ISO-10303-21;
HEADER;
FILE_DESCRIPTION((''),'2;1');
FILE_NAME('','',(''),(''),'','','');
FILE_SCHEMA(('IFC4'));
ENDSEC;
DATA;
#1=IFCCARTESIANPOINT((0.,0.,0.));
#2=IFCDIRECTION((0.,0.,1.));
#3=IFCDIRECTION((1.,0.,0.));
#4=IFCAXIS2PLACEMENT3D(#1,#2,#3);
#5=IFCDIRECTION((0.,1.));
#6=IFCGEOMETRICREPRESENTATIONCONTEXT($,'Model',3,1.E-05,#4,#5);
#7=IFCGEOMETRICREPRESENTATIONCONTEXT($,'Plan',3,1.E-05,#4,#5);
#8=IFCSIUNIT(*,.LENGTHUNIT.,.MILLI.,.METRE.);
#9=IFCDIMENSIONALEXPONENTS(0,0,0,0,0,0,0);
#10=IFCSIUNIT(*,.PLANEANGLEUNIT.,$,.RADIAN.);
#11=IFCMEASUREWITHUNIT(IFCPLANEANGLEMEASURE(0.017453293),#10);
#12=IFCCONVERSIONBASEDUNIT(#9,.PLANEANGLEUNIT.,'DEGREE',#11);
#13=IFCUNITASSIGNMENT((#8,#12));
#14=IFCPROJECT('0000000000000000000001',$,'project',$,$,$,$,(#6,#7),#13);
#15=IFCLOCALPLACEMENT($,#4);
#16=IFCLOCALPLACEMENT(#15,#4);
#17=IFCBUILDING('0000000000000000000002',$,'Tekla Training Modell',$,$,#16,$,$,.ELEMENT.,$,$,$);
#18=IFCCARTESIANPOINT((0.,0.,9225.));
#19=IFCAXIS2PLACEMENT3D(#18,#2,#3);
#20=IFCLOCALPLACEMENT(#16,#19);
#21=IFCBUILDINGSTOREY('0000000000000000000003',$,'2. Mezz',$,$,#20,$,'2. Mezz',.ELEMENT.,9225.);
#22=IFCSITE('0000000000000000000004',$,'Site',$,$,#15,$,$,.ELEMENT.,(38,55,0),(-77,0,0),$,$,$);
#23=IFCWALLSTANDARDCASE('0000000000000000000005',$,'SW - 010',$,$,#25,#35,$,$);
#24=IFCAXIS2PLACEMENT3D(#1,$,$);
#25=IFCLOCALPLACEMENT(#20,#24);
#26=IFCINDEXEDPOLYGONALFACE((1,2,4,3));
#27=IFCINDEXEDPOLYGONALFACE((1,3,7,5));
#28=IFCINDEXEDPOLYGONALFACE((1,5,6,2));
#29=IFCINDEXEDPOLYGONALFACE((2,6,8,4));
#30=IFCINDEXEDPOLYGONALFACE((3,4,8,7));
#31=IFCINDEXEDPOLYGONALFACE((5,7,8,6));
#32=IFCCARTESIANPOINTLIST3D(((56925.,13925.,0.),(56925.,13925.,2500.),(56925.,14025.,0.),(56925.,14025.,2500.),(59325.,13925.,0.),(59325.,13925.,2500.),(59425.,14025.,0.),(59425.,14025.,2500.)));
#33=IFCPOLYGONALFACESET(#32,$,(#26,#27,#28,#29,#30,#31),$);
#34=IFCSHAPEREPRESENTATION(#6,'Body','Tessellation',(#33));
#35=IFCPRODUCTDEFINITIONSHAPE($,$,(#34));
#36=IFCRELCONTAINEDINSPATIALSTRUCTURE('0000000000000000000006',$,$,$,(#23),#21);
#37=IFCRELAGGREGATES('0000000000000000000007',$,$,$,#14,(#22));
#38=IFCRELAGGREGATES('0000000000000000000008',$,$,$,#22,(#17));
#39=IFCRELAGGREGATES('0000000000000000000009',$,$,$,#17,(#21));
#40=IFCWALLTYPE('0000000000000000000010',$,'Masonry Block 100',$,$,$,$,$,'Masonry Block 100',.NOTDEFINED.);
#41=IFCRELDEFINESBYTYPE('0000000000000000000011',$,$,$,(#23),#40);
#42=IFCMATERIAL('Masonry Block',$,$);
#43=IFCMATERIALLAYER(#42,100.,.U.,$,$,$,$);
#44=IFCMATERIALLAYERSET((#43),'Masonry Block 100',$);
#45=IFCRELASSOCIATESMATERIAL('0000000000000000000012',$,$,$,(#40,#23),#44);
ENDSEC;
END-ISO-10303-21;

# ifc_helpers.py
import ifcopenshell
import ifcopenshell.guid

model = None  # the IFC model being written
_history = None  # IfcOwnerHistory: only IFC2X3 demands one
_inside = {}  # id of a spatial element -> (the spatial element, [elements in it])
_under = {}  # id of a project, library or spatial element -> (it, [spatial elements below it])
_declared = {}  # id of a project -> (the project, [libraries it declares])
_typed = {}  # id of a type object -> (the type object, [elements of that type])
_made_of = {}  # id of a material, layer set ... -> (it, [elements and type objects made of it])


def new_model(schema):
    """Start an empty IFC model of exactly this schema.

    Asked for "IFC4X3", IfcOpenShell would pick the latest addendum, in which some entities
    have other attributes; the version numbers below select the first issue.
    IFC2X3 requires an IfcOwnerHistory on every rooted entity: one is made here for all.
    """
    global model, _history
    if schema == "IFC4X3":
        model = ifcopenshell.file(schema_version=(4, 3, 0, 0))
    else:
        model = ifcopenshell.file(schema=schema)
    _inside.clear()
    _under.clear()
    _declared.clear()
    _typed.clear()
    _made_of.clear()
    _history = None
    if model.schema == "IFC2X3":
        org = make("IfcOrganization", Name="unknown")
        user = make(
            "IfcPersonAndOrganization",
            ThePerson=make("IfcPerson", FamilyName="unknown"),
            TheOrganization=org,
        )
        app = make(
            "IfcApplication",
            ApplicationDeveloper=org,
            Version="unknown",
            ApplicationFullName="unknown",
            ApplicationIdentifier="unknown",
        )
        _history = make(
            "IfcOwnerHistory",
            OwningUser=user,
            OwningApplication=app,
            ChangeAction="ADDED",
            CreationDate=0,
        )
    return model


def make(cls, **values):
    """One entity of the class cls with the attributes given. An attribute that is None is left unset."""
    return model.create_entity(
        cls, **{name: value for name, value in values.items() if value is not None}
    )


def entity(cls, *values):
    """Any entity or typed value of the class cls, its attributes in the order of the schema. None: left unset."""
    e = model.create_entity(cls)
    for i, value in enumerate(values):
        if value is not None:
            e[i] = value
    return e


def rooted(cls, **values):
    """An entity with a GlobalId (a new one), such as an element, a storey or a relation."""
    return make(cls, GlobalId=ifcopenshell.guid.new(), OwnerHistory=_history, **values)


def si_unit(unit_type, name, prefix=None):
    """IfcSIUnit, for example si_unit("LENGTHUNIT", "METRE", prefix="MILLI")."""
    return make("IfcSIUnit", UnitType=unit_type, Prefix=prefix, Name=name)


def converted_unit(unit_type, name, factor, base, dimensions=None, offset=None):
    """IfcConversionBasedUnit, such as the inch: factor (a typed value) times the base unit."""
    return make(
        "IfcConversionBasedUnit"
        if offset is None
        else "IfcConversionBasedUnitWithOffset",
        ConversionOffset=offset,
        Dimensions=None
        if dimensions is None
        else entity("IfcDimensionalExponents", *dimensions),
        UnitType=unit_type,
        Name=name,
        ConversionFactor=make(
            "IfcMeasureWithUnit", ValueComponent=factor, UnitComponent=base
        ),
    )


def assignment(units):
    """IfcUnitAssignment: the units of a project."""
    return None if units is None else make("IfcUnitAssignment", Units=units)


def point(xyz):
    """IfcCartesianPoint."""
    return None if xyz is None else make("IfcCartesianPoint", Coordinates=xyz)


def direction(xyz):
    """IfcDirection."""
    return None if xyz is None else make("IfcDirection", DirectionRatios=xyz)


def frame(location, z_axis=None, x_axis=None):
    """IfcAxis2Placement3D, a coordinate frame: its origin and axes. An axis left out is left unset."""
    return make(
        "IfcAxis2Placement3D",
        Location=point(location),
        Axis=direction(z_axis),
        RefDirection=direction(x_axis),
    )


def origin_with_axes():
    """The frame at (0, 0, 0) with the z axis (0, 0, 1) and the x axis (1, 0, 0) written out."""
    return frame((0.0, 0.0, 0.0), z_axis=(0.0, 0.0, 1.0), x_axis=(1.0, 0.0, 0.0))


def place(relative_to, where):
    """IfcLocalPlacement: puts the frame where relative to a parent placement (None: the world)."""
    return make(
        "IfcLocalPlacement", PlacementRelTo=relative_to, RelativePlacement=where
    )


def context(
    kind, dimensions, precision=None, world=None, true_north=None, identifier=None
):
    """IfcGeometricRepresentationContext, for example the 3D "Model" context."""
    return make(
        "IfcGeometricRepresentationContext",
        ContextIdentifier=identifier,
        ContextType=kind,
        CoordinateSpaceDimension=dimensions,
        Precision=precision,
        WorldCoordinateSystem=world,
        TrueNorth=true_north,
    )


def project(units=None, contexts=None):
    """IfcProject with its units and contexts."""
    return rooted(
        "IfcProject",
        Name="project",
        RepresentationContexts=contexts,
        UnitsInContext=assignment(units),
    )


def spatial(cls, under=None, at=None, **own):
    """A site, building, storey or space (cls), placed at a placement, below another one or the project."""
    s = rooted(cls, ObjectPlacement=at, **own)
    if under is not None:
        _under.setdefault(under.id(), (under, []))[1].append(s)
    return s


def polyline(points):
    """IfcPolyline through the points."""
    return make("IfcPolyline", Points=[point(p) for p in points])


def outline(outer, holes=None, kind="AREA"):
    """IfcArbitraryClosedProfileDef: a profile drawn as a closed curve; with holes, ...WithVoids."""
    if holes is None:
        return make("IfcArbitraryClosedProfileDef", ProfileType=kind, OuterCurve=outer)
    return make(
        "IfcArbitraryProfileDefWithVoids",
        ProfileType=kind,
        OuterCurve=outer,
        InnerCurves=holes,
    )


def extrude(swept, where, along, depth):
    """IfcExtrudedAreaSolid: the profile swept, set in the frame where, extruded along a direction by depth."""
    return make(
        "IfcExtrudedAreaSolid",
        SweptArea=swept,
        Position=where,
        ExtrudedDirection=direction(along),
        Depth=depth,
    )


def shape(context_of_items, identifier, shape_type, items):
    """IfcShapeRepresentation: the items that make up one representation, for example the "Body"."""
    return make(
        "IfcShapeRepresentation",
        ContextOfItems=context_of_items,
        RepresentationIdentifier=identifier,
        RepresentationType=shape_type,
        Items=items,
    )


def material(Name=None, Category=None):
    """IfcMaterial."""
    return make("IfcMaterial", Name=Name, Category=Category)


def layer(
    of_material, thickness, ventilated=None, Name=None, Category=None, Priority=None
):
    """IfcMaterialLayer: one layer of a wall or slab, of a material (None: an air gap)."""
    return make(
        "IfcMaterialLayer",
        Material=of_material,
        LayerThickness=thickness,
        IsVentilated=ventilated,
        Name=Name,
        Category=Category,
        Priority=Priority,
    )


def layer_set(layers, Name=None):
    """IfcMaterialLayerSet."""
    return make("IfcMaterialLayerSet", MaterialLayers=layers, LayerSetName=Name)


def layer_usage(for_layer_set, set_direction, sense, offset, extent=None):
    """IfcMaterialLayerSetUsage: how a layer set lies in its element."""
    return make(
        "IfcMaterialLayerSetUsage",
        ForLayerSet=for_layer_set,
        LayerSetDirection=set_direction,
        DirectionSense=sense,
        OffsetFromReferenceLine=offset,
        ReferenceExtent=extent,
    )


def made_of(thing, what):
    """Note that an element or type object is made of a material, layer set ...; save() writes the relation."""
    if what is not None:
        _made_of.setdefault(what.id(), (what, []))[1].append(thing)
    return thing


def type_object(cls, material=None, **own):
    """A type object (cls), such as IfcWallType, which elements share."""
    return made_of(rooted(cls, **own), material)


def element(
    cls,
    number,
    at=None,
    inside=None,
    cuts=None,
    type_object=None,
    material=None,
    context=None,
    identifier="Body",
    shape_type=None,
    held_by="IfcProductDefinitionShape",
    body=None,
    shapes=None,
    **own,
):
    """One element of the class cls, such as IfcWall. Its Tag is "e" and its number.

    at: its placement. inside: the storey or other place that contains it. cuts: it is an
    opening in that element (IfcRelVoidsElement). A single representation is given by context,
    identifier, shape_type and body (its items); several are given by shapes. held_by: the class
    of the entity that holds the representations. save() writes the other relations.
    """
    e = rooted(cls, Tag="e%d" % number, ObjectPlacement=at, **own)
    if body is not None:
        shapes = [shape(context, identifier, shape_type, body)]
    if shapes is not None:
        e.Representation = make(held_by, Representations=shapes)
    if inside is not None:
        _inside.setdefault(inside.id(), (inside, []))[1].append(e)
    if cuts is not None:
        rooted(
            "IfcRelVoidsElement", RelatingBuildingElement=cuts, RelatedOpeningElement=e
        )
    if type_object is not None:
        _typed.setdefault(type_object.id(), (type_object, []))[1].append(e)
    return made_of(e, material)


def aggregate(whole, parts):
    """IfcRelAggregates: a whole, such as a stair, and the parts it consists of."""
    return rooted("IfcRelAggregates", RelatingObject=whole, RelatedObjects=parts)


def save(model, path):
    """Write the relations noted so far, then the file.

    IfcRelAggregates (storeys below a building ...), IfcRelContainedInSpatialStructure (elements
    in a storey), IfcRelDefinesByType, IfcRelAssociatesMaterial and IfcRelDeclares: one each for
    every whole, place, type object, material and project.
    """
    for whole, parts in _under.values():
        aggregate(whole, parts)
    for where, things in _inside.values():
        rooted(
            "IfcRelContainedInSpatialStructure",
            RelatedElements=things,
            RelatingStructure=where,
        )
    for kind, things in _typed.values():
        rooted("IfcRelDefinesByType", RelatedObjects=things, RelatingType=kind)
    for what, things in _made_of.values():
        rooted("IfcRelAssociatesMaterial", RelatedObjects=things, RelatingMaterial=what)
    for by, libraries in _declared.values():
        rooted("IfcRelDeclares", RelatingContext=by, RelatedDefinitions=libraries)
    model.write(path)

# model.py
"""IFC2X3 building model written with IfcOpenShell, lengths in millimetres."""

from ifc_helpers import new_model, entity, si_unit, converted_unit, direction, frame, origin_with_axes, place, context, project, spatial, polyline, outline, extrude, material, layer, layer_set, layer_usage, type_object, element, save


model = new_model("IFC2X3")

# Units and contexts
model_context = context("Model", 3, precision=1e-05, world=origin_with_axes(), true_north=direction((0.0, 1.0)))
plan_context = context("Plan", 3, precision=1e-05, world=origin_with_axes(), true_north=direction((0.0, 1.0)))
ifc_project = project(units=[si_unit("LENGTHUNIT", "METRE", prefix="MILLI"), converted_unit("PLANEANGLEUNIT", "DEGREE", entity("IfcPlaneAngleMeasure", 0.017453293), si_unit("PLANEANGLEUNIT", "RADIAN"), dimensions=[0, 0, 0, 0, 0, 0, 0])], contexts=[model_context, plan_context])

# Site, building, storey
site_placement = place(None, origin_with_axes())
site = spatial("IfcSite", under=ifc_project, at=site_placement, Name="Site", CompositionType="ELEMENT", RefLatitude=(38, 55, 0), RefLongitude=(-77, 0, 0))
building_placement = place(site_placement, origin_with_axes())
building = spatial("IfcBuilding", under=site, at=building_placement, Name="Tekla Training Modell", CompositionType="ELEMENT")
storey_placement = place(building_placement, frame((0.0, 0.0, 9225.0), z_axis=(0.0, 0.0, 1.0), x_axis=(1.0, 0.0, 0.0)))
storey = spatial("IfcBuildingStorey", under=building, at=storey_placement, Name="2. Mezz", LongName="2. Mezz", CompositionType="ELEMENT", Elevation=9225.0)

# Wall
ifc_material_1 = material(Name="Masonry Block")
ifc_layer_1 = layer(ifc_material_1, 100.0, ventilated="UNKNOWN")
ifc_layer_set_1 = layer_set([ifc_layer_1], Name="Masonry Block 100")
ifc_layer_usage_1 = layer_usage(ifc_layer_set_1, "AXIS2", "POSITIVE", -50.0)
wall_type = type_object("IfcWallType", Name="Masonry Block 100", ElementType="Masonry Block 100", PredefinedType="NOTDEFINED", material=ifc_layer_set_1)
wall_placement = place(storey_placement, frame((59375.0, 13975.0, 0.0), z_axis=(0.0, 0.0, 1.0), x_axis=(-1.0, 0.0, 0.0)))
element("IfcWallStandardCase", 1, at=wall_placement, inside=storey, type_object=wall_type, material=ifc_layer_usage_1, Name="SW - 010", context=model_context, shape_type="SweptSolid", body=[
    extrude(outline(polyline([(-50.0, -50.0), (2450.0, -50.0), (2450.0, 50.0), (50.0, 50.0), (-50.0, -50.0)])), origin_with_axes(), (0.0, 0.0, 1.0), 2500.0),
])

save(model, "model.ifc")
